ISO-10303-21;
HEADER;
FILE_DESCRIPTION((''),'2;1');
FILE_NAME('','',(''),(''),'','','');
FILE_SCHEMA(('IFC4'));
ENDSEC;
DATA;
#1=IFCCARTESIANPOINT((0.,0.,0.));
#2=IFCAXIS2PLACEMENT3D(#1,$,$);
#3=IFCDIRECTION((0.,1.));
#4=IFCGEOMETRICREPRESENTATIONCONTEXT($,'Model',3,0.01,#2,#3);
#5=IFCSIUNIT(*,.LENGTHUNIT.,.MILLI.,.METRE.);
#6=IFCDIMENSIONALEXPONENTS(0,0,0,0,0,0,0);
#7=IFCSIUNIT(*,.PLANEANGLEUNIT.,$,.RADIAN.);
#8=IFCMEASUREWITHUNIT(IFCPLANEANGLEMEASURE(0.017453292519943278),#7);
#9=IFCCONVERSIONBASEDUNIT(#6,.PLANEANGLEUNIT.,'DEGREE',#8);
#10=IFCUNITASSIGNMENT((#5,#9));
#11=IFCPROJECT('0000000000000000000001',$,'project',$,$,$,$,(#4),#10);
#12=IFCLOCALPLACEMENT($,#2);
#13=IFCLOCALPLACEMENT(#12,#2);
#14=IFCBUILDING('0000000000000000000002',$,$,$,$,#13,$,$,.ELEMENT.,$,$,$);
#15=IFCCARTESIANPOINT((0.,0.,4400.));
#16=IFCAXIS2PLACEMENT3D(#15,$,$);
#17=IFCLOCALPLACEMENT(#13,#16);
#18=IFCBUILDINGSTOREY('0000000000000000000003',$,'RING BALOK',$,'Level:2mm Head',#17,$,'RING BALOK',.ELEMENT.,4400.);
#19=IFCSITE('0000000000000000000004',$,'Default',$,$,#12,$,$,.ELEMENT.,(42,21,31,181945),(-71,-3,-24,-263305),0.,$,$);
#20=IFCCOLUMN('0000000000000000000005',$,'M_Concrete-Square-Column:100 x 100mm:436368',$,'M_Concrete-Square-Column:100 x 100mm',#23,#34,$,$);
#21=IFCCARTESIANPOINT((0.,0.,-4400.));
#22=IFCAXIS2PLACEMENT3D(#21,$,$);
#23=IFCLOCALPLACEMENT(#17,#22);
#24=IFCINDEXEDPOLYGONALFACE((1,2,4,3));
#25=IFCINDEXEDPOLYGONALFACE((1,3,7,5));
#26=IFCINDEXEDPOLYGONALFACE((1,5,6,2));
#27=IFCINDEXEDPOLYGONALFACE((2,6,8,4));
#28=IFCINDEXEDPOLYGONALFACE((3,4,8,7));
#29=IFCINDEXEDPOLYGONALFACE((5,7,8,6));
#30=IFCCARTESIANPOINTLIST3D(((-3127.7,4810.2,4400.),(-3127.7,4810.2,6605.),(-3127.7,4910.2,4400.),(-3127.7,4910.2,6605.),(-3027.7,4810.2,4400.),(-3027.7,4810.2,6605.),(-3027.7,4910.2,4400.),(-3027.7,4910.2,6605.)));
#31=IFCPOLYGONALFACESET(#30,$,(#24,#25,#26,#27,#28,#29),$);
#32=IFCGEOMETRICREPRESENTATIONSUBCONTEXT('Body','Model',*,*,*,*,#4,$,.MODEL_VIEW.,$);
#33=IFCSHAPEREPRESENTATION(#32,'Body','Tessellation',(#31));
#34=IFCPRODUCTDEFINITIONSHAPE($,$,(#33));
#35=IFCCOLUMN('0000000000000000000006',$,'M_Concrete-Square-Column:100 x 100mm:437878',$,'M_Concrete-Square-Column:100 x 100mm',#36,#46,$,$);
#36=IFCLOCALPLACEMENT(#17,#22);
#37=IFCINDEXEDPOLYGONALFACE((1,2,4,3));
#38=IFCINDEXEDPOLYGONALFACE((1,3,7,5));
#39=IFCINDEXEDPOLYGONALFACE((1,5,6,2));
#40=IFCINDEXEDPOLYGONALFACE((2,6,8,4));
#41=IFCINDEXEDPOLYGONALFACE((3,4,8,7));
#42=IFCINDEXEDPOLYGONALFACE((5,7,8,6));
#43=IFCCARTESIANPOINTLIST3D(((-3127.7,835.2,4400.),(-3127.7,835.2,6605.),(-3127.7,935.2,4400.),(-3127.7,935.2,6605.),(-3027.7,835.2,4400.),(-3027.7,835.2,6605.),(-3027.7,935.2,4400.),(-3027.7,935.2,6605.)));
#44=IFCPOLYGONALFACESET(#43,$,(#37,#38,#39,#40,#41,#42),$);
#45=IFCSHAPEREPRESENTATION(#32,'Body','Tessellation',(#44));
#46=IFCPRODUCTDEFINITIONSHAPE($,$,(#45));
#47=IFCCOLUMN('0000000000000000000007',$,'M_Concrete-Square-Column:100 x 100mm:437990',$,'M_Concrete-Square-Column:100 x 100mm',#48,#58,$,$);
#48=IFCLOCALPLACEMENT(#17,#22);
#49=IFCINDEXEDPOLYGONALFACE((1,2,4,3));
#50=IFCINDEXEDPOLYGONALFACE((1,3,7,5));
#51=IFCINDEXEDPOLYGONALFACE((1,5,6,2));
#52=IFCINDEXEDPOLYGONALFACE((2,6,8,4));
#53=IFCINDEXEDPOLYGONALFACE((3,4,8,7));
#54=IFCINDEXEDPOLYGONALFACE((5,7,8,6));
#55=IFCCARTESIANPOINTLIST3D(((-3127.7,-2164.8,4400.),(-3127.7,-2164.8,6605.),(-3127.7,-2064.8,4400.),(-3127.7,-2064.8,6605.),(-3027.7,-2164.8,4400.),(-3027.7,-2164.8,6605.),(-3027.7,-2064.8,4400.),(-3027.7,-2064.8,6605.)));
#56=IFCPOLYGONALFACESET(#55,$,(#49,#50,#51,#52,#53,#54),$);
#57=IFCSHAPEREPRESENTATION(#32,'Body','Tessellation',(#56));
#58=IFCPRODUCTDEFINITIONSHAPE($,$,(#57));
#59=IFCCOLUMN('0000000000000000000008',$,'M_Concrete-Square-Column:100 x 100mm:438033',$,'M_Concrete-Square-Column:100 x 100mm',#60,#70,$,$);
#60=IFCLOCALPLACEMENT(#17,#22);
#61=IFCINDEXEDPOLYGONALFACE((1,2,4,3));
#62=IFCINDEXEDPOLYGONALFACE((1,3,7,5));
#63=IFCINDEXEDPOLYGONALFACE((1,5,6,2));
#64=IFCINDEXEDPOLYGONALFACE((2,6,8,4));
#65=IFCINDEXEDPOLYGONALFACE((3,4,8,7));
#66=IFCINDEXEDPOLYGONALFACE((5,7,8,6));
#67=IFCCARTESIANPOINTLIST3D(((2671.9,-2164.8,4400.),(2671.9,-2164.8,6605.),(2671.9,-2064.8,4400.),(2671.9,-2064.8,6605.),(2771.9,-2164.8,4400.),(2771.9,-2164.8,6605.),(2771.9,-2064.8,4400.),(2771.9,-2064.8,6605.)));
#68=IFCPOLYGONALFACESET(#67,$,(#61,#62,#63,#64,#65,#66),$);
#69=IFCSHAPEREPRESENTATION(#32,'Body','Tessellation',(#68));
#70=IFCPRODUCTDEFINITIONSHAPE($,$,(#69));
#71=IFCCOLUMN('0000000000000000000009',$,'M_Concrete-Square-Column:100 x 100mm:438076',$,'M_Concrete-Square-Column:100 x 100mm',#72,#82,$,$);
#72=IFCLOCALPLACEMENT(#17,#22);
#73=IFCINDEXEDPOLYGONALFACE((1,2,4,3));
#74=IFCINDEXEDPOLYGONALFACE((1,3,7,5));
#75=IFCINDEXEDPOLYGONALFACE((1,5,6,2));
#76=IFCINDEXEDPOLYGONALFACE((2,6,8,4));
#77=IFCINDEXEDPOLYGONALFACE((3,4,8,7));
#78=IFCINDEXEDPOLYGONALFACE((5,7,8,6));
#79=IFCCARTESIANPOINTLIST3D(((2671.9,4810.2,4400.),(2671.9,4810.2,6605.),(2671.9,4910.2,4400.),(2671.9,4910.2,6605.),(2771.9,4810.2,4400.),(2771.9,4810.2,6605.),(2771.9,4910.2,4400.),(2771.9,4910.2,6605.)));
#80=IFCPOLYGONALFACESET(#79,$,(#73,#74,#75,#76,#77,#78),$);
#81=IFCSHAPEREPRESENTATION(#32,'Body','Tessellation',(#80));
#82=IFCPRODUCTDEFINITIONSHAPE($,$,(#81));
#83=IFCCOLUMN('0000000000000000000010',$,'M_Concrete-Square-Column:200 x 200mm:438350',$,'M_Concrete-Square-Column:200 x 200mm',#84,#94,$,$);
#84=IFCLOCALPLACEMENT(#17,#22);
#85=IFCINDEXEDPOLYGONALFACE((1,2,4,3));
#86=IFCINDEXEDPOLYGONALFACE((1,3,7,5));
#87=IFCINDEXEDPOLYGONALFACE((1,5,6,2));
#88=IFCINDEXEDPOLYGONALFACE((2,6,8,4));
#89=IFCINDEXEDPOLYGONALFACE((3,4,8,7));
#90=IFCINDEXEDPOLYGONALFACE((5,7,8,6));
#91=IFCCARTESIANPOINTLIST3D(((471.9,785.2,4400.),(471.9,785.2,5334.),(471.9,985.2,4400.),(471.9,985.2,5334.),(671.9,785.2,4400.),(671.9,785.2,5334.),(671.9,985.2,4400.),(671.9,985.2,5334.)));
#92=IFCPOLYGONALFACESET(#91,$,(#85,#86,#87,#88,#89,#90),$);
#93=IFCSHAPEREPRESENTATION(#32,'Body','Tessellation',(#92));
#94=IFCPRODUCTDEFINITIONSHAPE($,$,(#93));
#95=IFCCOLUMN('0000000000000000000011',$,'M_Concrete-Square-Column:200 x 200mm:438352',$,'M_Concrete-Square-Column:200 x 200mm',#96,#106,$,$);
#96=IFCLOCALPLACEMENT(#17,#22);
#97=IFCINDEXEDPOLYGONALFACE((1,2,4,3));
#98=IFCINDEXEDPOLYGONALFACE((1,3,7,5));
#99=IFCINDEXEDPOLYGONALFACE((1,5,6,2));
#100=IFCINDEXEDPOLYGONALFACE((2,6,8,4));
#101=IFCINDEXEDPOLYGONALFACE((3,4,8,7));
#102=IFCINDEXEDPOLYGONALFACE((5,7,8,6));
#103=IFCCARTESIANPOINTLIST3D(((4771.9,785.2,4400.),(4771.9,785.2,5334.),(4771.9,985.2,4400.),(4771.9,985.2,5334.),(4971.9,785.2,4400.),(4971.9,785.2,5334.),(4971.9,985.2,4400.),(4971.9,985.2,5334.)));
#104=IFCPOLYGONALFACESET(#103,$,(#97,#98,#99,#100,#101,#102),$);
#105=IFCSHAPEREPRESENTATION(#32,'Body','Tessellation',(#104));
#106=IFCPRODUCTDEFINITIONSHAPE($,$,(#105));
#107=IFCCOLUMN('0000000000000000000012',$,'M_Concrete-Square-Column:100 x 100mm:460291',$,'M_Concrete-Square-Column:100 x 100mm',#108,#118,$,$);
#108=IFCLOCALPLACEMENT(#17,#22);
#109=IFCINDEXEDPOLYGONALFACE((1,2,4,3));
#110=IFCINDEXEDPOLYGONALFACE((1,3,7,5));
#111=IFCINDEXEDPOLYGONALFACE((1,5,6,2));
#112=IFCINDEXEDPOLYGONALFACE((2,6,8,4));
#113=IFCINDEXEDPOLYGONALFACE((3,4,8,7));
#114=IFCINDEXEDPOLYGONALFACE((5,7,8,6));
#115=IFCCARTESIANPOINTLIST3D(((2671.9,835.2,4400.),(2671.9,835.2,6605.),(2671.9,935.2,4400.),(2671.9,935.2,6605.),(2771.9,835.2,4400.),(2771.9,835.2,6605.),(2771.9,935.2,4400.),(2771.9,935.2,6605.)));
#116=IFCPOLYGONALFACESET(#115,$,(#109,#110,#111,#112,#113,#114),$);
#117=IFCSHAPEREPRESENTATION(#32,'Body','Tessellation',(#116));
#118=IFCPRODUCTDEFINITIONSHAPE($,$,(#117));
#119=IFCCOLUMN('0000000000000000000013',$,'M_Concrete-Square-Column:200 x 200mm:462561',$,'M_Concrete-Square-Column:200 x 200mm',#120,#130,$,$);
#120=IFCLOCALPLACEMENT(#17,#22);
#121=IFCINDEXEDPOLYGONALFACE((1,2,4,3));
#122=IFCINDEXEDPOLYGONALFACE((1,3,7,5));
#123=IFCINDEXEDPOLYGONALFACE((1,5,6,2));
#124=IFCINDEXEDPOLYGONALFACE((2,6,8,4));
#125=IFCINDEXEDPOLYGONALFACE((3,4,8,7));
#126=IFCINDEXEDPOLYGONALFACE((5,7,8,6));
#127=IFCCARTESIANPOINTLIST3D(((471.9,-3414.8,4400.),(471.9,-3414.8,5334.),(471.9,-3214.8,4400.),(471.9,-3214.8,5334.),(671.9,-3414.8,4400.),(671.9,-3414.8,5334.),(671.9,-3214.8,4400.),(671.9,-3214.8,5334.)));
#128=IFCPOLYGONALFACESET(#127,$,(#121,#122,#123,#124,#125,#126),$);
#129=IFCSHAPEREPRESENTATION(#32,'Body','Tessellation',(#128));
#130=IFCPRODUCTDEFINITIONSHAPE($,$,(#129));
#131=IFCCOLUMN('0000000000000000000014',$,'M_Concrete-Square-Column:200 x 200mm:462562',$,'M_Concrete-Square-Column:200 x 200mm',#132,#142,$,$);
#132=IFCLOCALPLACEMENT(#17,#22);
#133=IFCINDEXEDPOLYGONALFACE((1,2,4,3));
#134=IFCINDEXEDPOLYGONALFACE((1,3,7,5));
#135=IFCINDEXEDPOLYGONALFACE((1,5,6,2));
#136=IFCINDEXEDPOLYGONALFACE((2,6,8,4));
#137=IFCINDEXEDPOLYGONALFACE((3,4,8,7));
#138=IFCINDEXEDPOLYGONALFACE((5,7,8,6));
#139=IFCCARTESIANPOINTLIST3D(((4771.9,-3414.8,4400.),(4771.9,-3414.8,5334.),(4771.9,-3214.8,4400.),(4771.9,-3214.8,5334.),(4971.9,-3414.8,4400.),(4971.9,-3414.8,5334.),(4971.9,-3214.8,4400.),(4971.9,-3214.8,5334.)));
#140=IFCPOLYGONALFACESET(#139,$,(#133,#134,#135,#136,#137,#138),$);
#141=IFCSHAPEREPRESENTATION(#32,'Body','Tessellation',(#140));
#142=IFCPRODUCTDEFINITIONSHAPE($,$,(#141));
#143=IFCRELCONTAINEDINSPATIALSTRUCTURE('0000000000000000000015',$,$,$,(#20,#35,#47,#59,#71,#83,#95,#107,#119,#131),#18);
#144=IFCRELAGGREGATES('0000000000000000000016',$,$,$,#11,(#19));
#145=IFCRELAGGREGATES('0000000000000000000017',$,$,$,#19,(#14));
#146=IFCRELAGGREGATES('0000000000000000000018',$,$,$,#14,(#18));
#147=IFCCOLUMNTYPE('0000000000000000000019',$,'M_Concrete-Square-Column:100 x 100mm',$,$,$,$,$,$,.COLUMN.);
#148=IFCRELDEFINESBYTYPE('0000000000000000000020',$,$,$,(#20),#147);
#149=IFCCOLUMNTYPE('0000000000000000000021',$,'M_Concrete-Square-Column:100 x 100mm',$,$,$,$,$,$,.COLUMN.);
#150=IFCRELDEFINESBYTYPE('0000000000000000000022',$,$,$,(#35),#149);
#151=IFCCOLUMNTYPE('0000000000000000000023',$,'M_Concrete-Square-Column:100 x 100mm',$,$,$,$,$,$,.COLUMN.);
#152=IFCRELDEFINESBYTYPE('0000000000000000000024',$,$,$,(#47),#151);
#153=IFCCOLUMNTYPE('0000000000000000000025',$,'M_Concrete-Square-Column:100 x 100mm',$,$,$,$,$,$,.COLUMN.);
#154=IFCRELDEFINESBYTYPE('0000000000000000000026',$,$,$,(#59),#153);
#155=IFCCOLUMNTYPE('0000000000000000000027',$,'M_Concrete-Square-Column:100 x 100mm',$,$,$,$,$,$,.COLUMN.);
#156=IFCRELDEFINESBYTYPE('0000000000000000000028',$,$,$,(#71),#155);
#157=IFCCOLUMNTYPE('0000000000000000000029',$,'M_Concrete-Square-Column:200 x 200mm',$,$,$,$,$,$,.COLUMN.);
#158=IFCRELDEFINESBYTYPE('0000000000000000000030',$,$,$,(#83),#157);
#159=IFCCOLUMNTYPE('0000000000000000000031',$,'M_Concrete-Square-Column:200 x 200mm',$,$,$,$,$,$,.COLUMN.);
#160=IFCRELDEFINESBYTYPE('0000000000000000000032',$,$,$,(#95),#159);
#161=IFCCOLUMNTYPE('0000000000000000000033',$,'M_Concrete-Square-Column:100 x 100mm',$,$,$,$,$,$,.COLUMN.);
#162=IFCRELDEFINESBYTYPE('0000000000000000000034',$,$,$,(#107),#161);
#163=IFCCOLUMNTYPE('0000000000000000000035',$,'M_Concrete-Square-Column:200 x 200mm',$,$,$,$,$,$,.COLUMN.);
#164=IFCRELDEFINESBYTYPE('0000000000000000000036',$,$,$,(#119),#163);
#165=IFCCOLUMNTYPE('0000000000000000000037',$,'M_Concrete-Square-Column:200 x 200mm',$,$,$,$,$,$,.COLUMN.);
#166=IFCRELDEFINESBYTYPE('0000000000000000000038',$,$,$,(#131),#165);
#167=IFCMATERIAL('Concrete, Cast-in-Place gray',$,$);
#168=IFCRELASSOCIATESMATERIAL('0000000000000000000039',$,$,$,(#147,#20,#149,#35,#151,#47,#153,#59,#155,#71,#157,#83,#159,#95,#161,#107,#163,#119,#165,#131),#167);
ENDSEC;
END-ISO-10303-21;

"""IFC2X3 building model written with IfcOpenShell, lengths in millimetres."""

from ifc_helpers import new_model, entity, si_unit, converted_unit, direction, frame, frame_2d, origin, origin_2d_with_axis, place, context, subcontext, project, spatial, rectangle, extrude, source, transform, mapped, material, type_object, type_shapes, element, save


model = new_model("IFC2X3")

# Units and contexts
model_context = context("Model", 3, precision=0.01, world=origin(), true_north=direction((0.0, 1.0)))
body_context = subcontext(model_context, "Body", "Model", "MODEL_VIEW")
ifc_project = project(units=[si_unit("LENGTHUNIT", "METRE", prefix="MILLI"), converted_unit("PLANEANGLEUNIT", "DEGREE", entity("IfcPlaneAngleMeasure", 0.017453292519943278), si_unit("PLANEANGLEUNIT", "RADIAN"), dimensions=[0, 0, 0, 0, 0, 0, 0])], contexts=[model_context])

# Site, building, storey
site_placement = place(None, origin())
site = spatial("IfcSite", under=ifc_project, at=site_placement, Name="Default", CompositionType="ELEMENT", RefLatitude=(42, 21, 31, 181945), RefLongitude=(-71, -3, -24, -263305), RefElevation=0.0)
building_placement = place(site_placement, origin())
building = spatial("IfcBuilding", under=site, at=building_placement, CompositionType="ELEMENT")
storey_placement = place(building_placement, frame((0.0, 0.0, 4400.0)))
storey = spatial("IfcBuildingStorey", under=building, at=storey_placement, Name="RING BALOK", ObjectType="Level:2mm Head", LongName="RING BALOK", CompositionType="ELEMENT", Elevation=4400.0)

# Columns
ifc_material = material(Name="Concrete, Cast-in-Place gray")
column_type_1 = type_object("IfcColumnType", Name="M_Concrete-Square-Column:100 x 100mm", PredefinedType="COLUMN", material=ifc_material)
shared_shape_1 = source(origin(), body_context, "Body", "SweptSolid", [
    extrude(rectangle(XDim=100.0, YDim=100.0, at=origin_2d_with_axis()), frame((-3077.7, 4860.2, 4400.0), z_axis=(0.0, 0.0, 1.0), x_axis=(-1.0, 0.0, 0.0)), (0.0, 0.0, 1.0), 2205.0),
])
type_shapes(column_type_1, [shared_shape_1])
column_1_placement = place(storey_placement, frame((0.0, 0.0, -4400.0)))
element("IfcColumn", 1, at=column_1_placement, inside=storey, type_object=column_type_1, material=ifc_material, Name="M_Concrete-Square-Column:100 x 100mm:436368", ObjectType="M_Concrete-Square-Column:100 x 100mm", context=body_context, shape_type="MappedRepresentation", body=[
    mapped(shared_shape_1, transform((0.0, 0.0, 0.0), scale=1.0)),
])
column_type_2 = type_object("IfcColumnType", Name="M_Concrete-Square-Column:100 x 100mm", PredefinedType="COLUMN", material=ifc_material)
shared_shape_2 = source(origin(), body_context, "Body", "SweptSolid", [
    extrude(rectangle(XDim=100.0, YDim=100.0, at=origin_2d_with_axis()), frame((-3077.7, 885.2, 4400.0), z_axis=(0.0, 0.0, 1.0), x_axis=(-1.0, 0.0, 0.0)), (0.0, 0.0, 1.0), 2205.0),
])
type_shapes(column_type_2, [shared_shape_2])
column_2_placement = place(storey_placement, frame((0.0, 0.0, -4400.0)))
element("IfcColumn", 2, at=column_2_placement, inside=storey, type_object=column_type_2, material=ifc_material, Name="M_Concrete-Square-Column:100 x 100mm:437878", ObjectType="M_Concrete-Square-Column:100 x 100mm", context=body_context, shape_type="MappedRepresentation", body=[
    mapped(shared_shape_2, transform((0.0, 0.0, 0.0), scale=1.0)),
])
column_type_3 = type_object("IfcColumnType", Name="M_Concrete-Square-Column:100 x 100mm", PredefinedType="COLUMN", material=ifc_material)
shared_shape_3 = source(origin(), body_context, "Body", "SweptSolid", [
    extrude(rectangle(XDim=100.0, YDim=100.0, at=origin_2d_with_axis()), frame((-3077.7, -2114.8, 4400.0), z_axis=(0.0, 0.0, 1.0), x_axis=(-1.0, 0.0, 0.0)), (0.0, 0.0, 1.0), 2205.0),
])
type_shapes(column_type_3, [shared_shape_3])
column_3_placement = place(storey_placement, frame((0.0, 0.0, -4400.0)))
element("IfcColumn", 3, at=column_3_placement, inside=storey, type_object=column_type_3, material=ifc_material, Name="M_Concrete-Square-Column:100 x 100mm:437990", ObjectType="M_Concrete-Square-Column:100 x 100mm", context=body_context, shape_type="MappedRepresentation", body=[
    mapped(shared_shape_3, transform((0.0, 0.0, 0.0), scale=1.0)),
])
column_type_4 = type_object("IfcColumnType", Name="M_Concrete-Square-Column:100 x 100mm", PredefinedType="COLUMN", material=ifc_material)
shared_shape_4 = source(origin(), body_context, "Body", "SweptSolid", [
    extrude(rectangle(XDim=100.0, YDim=100.0, at=origin_2d_with_axis()), frame((2721.9, -2114.8, 4400.0), z_axis=(0.0, 0.0, 1.0), x_axis=(-1.0, 0.0, 0.0)), (0.0, 0.0, 1.0), 2205.0),
])
type_shapes(column_type_4, [shared_shape_4])
column_4_placement = place(storey_placement, frame((0.0, 0.0, -4400.0)))
element("IfcColumn", 4, at=column_4_placement, inside=storey, type_object=column_type_4, material=ifc_material, Name="M_Concrete-Square-Column:100 x 100mm:438033", ObjectType="M_Concrete-Square-Column:100 x 100mm", context=body_context, shape_type="MappedRepresentation", body=[
    mapped(shared_shape_4, transform((0.0, 0.0, 0.0), scale=1.0)),
])
column_type_5 = type_object("IfcColumnType", Name="M_Concrete-Square-Column:100 x 100mm", PredefinedType="COLUMN", material=ifc_material)
shared_shape_5 = source(origin(), body_context, "Body", "SweptSolid", [
    extrude(rectangle(XDim=100.0, YDim=100.0, at=origin_2d_with_axis()), frame((2721.9, 4860.2, 4400.0), z_axis=(0.0, 0.0, 1.0), x_axis=(-1.0, 0.0, 0.0)), (0.0, 0.0, 1.0), 2205.0),
])
type_shapes(column_type_5, [shared_shape_5])
column_5_placement = place(storey_placement, frame((0.0, 0.0, -4400.0)))
element("IfcColumn", 5, at=column_5_placement, inside=storey, type_object=column_type_5, material=ifc_material, Name="M_Concrete-Square-Column:100 x 100mm:438076", ObjectType="M_Concrete-Square-Column:100 x 100mm", context=body_context, shape_type="MappedRepresentation", body=[
    mapped(shared_shape_5, transform((0.0, 0.0, 0.0), scale=1.0)),
])
column_type_6 = type_object("IfcColumnType", Name="M_Concrete-Square-Column:200 x 200mm", PredefinedType="COLUMN", material=ifc_material)
shared_shape_6 = source(origin(), body_context, "Body", "SweptSolid", [
    extrude(rectangle(XDim=200.0, YDim=200.0, at=origin_2d_with_axis()), frame((571.9, 885.2, 4400.0), z_axis=(0.0, 0.0, 1.0), x_axis=(-1.0, 0.0, 0.0)), (0.0, 0.0, 1.0), 934.0),
])
type_shapes(column_type_6, [shared_shape_6])
column_6_placement = place(storey_placement, frame((0.0, 0.0, -4400.0)))
element("IfcColumn", 6, at=column_6_placement, inside=storey, type_object=column_type_6, material=ifc_material, Name="M_Concrete-Square-Column:200 x 200mm:438350", ObjectType="M_Concrete-Square-Column:200 x 200mm", context=body_context, shape_type="MappedRepresentation", body=[
    mapped(shared_shape_6, transform((0.0, 0.0, 0.0), scale=1.0)),
])
column_type_7 = type_object("IfcColumnType", Name="M_Concrete-Square-Column:200 x 200mm", PredefinedType="COLUMN", material=ifc_material)
shared_shape_7 = source(origin(), body_context, "Body", "SweptSolid", [
    extrude(rectangle(XDim=200.0, YDim=200.0, at=origin_2d_with_axis()), frame((4871.9, 885.2, 4400.0), z_axis=(0.0, 0.0, 1.0), x_axis=(-1.0, 0.0, 0.0)), (0.0, 0.0, 1.0), 934.0),
])
type_shapes(column_type_7, [shared_shape_7])
column_7_placement = place(storey_placement, frame((0.0, 0.0, -4400.0)))
element("IfcColumn", 7, at=column_7_placement, inside=storey, type_object=column_type_7, material=ifc_material, Name="M_Concrete-Square-Column:200 x 200mm:438352", ObjectType="M_Concrete-Square-Column:200 x 200mm", context=body_context, shape_type="MappedRepresentation", body=[
    mapped(shared_shape_7, transform((0.0, 0.0, 0.0), scale=1.0)),
])
column_type_8 = type_object("IfcColumnType", Name="M_Concrete-Square-Column:100 x 100mm", PredefinedType="COLUMN", material=ifc_material)
shared_shape_8 = source(origin(), body_context, "Body", "SweptSolid", [
    extrude(rectangle(XDim=100.0, YDim=100.0, at=origin_2d_with_axis()), frame((2721.9, 885.2, 4400.0), z_axis=(0.0, 0.0, 1.0), x_axis=(-1.0, 0.0, 0.0)), (0.0, 0.0, 1.0), 2205.0),
])
type_shapes(column_type_8, [shared_shape_8])
column_8_placement = place(storey_placement, frame((0.0, 0.0, -4400.0)))
element("IfcColumn", 8, at=column_8_placement, inside=storey, type_object=column_type_8, material=ifc_material, Name="M_Concrete-Square-Column:100 x 100mm:460291", ObjectType="M_Concrete-Square-Column:100 x 100mm", context=body_context, shape_type="MappedRepresentation", body=[
    mapped(shared_shape_8, transform((0.0, 0.0, 0.0), scale=1.0)),
])
column_type_9 = type_object("IfcColumnType", Name="M_Concrete-Square-Column:200 x 200mm", PredefinedType="COLUMN", material=ifc_material)
shared_shape_9 = source(origin(), body_context, "Body", "SweptSolid", [
    extrude(rectangle(XDim=200.0, YDim=200.0, at=origin_2d_with_axis()), frame((571.9, -3314.8, 4400.0), z_axis=(0.0, 0.0, 1.0), x_axis=(-1.0, 0.0, 0.0)), (0.0, 0.0, 1.0), 934.0),
])
type_shapes(column_type_9, [shared_shape_9])
column_9_placement = place(storey_placement, frame((0.0, 0.0, -4400.0)))
element("IfcColumn", 9, at=column_9_placement, inside=storey, type_object=column_type_9, material=ifc_material, Name="M_Concrete-Square-Column:200 x 200mm:462561", ObjectType="M_Concrete-Square-Column:200 x 200mm", context=body_context, shape_type="MappedRepresentation", body=[
    mapped(shared_shape_9, transform((0.0, 0.0, 0.0), scale=1.0)),
])
column_type_10 = type_object("IfcColumnType", Name="M_Concrete-Square-Column:200 x 200mm", PredefinedType="COLUMN", material=ifc_material)
shared_shape_10 = source(origin(), body_context, "Body", "SweptSolid", [
    extrude(rectangle(XDim=200.0, YDim=200.0, at=frame_2d((0.0, 0.0), x_axis=(1.0, 0.0))), frame((4871.9, -3314.8, 4400.0), z_axis=(0.0, 0.0, 1.0), x_axis=(-1.0, 0.0, 0.0)), (0.0, 0.0, 1.0), 934.0),
])
type_shapes(column_type_10, [shared_shape_10])
column_10_placement = place(storey_placement, frame((0.0, 0.0, -4400.0)))
element("IfcColumn", 10, at=column_10_placement, inside=storey, type_object=column_type_10, material=ifc_material, Name="M_Concrete-Square-Column:200 x 200mm:462562", ObjectType="M_Concrete-Square-Column:200 x 200mm", context=body_context, shape_type="MappedRepresentation", body=[
    mapped(shared_shape_10, transform((0.0, 0.0, 0.0), scale=1.0)),
])

save(model, "model.ifc")
